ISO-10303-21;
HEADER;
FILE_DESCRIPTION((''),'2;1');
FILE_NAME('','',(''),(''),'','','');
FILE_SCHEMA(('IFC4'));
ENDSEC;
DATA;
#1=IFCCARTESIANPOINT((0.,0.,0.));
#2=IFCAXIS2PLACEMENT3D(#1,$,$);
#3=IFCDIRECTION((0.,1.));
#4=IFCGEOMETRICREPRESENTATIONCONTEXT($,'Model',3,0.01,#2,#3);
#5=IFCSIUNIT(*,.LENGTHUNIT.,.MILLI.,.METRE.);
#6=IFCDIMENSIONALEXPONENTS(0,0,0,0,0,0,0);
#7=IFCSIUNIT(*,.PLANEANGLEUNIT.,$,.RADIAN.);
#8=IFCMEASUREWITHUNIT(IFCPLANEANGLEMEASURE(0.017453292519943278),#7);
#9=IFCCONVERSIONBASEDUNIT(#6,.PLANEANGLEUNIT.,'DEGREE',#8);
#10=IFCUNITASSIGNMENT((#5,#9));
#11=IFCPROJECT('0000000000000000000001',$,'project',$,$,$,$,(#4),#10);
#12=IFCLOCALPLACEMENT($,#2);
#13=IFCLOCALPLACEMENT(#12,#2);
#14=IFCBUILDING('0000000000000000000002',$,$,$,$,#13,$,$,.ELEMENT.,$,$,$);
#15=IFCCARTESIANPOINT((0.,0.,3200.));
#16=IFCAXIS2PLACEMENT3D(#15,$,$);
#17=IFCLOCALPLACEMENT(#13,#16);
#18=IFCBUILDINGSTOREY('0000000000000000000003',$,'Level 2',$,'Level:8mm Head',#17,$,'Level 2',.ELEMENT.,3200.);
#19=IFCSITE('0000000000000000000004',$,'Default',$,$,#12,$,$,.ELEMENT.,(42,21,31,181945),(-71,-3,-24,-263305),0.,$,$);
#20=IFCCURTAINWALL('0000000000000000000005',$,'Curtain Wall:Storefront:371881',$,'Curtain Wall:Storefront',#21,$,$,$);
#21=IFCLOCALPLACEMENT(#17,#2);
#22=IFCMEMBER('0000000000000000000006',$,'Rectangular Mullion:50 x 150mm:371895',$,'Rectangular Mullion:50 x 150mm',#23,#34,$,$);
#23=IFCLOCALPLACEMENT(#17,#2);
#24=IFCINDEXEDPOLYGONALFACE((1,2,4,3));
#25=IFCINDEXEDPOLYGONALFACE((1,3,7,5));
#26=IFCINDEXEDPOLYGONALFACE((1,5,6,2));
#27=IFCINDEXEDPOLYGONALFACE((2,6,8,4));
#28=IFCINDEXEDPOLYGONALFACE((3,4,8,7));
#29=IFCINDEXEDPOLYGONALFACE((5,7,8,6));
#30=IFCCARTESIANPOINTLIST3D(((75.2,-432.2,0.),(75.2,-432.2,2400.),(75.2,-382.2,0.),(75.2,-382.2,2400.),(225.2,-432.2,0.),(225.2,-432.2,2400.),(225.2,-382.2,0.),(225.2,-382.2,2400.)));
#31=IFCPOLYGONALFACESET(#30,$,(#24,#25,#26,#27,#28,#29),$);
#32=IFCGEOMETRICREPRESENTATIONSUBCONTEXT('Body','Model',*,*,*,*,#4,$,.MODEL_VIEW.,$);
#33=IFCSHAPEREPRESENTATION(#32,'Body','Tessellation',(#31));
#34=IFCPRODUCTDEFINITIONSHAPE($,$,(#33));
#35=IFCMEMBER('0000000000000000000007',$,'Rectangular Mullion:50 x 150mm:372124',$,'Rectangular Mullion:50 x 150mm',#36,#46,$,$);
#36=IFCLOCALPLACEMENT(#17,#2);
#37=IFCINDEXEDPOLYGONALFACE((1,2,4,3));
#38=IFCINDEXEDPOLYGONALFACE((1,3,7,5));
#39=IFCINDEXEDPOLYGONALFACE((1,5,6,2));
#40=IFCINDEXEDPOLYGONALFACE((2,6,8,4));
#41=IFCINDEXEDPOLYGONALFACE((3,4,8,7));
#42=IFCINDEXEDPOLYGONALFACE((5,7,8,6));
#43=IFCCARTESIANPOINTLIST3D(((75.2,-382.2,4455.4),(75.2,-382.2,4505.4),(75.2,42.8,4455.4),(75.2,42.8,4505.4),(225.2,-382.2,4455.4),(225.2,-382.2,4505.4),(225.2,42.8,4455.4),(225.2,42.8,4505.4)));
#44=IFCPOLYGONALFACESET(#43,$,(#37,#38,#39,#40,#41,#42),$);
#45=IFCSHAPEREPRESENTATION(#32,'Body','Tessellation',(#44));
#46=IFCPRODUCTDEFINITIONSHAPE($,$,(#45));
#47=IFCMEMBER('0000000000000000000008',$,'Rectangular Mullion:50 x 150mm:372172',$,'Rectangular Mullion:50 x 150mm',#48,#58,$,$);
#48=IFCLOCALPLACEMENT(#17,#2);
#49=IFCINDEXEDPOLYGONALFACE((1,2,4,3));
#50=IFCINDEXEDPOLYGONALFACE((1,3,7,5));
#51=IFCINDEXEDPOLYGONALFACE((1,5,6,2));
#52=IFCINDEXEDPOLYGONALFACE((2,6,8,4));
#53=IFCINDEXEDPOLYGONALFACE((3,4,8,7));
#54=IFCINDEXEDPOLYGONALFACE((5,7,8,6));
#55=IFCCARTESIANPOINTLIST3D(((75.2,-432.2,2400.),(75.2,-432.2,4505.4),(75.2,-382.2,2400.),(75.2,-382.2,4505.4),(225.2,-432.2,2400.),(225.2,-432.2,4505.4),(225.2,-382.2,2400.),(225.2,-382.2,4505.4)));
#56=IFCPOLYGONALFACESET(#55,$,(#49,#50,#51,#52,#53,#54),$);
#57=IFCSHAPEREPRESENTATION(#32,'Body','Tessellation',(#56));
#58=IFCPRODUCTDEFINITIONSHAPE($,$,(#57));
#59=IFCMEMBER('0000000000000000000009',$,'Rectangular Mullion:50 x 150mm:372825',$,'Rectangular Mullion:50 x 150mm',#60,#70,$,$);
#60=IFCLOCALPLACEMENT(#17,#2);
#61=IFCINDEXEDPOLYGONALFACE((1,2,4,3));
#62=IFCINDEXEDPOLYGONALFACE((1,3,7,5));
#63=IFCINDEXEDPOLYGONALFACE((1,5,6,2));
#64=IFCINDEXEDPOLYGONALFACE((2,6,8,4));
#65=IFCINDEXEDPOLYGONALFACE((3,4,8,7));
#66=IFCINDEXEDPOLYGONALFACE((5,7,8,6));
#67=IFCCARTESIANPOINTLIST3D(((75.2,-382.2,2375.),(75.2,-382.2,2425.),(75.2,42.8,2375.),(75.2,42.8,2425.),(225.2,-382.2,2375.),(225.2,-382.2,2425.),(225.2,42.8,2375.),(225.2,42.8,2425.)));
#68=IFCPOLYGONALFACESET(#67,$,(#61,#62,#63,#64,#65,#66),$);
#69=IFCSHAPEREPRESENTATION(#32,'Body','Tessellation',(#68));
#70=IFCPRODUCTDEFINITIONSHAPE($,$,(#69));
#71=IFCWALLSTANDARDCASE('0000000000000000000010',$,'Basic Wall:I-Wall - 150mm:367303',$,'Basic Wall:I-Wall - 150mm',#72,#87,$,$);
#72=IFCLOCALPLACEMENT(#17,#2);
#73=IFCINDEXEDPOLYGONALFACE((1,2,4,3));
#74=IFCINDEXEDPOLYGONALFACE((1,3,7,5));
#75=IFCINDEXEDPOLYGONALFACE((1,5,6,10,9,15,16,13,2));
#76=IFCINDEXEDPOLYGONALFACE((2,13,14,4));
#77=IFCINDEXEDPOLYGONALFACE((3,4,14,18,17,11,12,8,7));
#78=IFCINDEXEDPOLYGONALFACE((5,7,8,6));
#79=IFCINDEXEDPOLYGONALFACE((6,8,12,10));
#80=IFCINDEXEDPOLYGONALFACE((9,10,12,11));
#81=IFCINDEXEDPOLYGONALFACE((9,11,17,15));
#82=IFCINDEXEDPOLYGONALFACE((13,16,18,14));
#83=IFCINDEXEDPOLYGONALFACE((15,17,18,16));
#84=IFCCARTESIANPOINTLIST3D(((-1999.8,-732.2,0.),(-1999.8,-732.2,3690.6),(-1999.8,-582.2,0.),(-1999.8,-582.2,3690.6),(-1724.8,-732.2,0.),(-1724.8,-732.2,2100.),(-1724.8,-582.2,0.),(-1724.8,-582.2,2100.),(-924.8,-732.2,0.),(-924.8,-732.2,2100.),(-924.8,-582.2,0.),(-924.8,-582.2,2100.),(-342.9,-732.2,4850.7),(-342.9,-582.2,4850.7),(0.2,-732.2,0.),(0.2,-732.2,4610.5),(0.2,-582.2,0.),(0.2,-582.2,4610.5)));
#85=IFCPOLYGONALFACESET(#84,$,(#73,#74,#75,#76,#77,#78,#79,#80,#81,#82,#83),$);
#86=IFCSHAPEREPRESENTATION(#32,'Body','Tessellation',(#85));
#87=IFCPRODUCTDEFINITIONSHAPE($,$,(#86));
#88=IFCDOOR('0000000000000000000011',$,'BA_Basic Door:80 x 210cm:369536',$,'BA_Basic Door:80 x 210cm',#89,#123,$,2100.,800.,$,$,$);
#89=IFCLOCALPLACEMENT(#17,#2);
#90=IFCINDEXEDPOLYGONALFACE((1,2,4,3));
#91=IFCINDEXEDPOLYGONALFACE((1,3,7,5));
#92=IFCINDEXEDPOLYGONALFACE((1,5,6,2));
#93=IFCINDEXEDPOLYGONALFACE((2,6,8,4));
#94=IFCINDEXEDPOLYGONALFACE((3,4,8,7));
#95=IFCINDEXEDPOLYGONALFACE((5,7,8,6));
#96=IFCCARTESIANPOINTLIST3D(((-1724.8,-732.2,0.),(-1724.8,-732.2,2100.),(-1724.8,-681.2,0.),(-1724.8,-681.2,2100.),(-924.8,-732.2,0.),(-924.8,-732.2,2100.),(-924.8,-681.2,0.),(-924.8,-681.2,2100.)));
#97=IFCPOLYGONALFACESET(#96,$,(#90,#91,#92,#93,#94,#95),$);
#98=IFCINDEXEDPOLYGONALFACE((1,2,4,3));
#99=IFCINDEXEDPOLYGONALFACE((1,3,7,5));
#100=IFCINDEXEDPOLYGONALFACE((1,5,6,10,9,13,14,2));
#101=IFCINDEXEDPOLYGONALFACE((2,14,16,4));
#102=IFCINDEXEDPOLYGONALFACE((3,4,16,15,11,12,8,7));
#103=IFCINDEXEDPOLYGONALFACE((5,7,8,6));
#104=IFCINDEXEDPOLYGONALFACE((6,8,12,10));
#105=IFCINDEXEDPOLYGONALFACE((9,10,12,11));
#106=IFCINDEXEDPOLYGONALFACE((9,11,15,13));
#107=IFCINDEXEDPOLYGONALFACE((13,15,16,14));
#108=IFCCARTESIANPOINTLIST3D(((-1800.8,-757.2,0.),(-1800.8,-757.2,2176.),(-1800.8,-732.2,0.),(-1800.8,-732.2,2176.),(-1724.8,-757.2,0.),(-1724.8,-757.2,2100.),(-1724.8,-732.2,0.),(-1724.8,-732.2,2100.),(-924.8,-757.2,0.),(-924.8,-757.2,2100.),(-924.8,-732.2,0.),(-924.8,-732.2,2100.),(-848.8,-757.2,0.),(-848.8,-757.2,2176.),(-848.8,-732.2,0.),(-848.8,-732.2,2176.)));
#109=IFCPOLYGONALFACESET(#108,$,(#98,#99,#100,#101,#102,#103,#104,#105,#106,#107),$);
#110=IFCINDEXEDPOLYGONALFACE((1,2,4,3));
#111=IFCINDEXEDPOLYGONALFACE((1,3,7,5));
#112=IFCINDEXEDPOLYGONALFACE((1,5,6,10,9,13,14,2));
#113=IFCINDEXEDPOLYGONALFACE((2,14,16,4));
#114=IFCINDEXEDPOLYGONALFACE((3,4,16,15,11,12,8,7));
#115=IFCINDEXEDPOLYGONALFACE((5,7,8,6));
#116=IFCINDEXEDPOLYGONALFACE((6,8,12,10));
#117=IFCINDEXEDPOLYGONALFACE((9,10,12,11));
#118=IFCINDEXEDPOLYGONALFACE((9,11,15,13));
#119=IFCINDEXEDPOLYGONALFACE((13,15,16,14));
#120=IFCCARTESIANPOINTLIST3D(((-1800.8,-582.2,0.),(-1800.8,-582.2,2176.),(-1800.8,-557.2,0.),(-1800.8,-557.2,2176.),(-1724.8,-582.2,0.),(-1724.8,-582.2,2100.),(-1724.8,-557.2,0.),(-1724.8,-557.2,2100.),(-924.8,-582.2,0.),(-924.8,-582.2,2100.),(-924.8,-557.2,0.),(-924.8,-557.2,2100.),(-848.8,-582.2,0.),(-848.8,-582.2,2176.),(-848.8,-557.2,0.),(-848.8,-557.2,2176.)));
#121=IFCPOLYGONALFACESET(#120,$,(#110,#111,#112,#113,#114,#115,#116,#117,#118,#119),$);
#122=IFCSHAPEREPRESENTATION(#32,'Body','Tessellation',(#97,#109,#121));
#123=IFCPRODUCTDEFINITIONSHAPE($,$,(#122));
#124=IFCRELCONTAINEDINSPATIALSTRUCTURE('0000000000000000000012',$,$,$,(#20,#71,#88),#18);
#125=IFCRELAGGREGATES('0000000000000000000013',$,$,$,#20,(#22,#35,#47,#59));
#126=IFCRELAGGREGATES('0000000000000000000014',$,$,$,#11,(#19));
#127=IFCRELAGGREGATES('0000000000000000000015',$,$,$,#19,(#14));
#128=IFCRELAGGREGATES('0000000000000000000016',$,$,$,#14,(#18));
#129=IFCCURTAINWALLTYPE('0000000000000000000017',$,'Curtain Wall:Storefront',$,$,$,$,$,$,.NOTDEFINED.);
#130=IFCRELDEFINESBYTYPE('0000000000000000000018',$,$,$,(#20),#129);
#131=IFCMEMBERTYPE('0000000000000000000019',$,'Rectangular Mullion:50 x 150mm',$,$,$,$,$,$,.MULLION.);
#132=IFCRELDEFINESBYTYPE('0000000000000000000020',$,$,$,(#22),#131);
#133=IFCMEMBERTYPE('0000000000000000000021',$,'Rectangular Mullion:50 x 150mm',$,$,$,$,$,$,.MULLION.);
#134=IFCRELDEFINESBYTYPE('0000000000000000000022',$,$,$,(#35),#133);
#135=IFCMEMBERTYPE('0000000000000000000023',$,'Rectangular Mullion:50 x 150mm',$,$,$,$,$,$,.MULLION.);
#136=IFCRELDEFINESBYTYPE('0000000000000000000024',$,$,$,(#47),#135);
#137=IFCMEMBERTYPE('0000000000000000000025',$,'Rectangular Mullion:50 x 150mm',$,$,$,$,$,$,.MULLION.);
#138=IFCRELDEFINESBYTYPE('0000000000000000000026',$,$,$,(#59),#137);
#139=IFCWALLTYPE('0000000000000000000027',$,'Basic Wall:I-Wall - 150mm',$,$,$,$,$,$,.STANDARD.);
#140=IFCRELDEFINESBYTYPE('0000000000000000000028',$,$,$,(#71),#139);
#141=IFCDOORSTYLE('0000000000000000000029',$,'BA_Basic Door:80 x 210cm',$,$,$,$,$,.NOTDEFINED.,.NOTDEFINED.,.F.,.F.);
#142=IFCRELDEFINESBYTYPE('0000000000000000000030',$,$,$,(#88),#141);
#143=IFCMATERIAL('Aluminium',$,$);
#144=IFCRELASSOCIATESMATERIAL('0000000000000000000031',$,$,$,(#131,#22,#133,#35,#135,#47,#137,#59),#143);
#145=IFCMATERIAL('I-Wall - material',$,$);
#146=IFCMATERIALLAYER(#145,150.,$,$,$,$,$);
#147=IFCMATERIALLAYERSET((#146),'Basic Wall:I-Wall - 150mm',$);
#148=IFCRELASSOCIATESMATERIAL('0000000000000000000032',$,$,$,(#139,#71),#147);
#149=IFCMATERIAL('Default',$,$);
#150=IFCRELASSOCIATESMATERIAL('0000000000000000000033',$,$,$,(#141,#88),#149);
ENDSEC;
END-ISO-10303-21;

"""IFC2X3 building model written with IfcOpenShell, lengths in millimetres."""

from ifc_helpers import new_model, entity, si_unit, converted_unit, direction, frame, frame_2d, origin, origin_2d_with_axis, place, context, subcontext, project, spatial, polyline, rectangle, outline, extrude, clip, bounded_halfspace, source, transform, mapped, material, layer, layer_set, layer_usage, type_object, type_shapes, element, fill, aggregate, save


model = new_model("IFC2X3")

# Units and contexts
model_context = context("Model", 3, precision=0.01, world=origin(), true_north=direction((0.0, 1.0)))
body_context = subcontext(model_context, "Body", "Model", "MODEL_VIEW")
ifc_project = project(units=[si_unit("LENGTHUNIT", "METRE", prefix="MILLI"), converted_unit("PLANEANGLEUNIT", "DEGREE", entity("IfcPlaneAngleMeasure", 0.017453292519943278), si_unit("PLANEANGLEUNIT", "RADIAN"), dimensions=[0, 0, 0, 0, 0, 0, 0])], contexts=[model_context])

# Site, building, storey
site_placement = place(None, origin())
site = spatial("IfcSite", under=ifc_project, at=site_placement, Name="Default", CompositionType="ELEMENT", RefLatitude=(42, 21, 31, 181945), RefLongitude=(-71, -3, -24, -263305), RefElevation=0.0)
building_placement = place(site_placement, origin())
building = spatial("IfcBuilding", under=site, at=building_placement, CompositionType="ELEMENT")
storey_placement = place(building_placement, frame((0.0, 0.0, 3200.0)))
storey = spatial("IfcBuildingStorey", under=building, at=storey_placement, Name="Level 2", ObjectType="Level:8mm Head", LongName="Level 2", CompositionType="ELEMENT", Elevation=3200.0)

# Curtain wall, member
curtain_wall_type = type_object("IfcCurtainWallType", Name="Curtain Wall:Storefront", PredefinedType="NOTDEFINED")
curtain_wall_1_placement = place(storey_placement, frame((0.0, 0.0, -3200.0)))
curtain_wall_1 = element("IfcCurtainWall", 1, at=curtain_wall_1_placement, inside=storey, type_object=curtain_wall_type, Name="Curtain Wall:Storefront:371881", ObjectType="Curtain Wall:Storefront")
ifc_material_1 = material(Name="Aluminium")
member_type_1 = type_object("IfcMemberType", Name="Rectangular Mullion:50 x 150mm", PredefinedType="MULLION", material=ifc_material_1)
shared_shape_1 = source(origin(), body_context, "Body", "SweptSolid", [
    extrude(rectangle(XDim=50.0, YDim=150.0, at=origin_2d_with_axis()), frame((-25.0, 0.0, -2400.0), z_axis=(0.0, 0.0, 1.0), x_axis=(-1.0, 0.0, 0.0)), (0.0, 0.0, 1.0), 2400.0),
])
type_shapes(member_type_1, [shared_shape_1])
member_1_placement = place(curtain_wall_1_placement, frame((150.2, -432.2, 3200.0), z_axis=(0.0, 0.0, -1.0), x_axis=(0.0, -1.0, 0.0)))
member_1 = element("IfcMember", 2, at=member_1_placement, type_object=member_type_1, material=ifc_material_1, Name="Rectangular Mullion:50 x 150mm:371895", ObjectType="Rectangular Mullion:50 x 150mm", context=body_context, shape_type="MappedRepresentation", body=[
    mapped(shared_shape_1, transform((0.0, 0.0, 0.0), scale=1.0)),
])

# Members
member_type_2 = type_object("IfcMemberType", Name="Rectangular Mullion:50 x 150mm", PredefinedType="MULLION", material=ifc_material_1)
shared_shape_2 = source(origin(), body_context, "Body", "SweptSolid", [
    extrude(rectangle(XDim=50.0, YDim=150.0, at=origin_2d_with_axis()), frame((-25.0, 0.0, -425.0), z_axis=(0.0, 0.0, 1.0), x_axis=(-1.0, 0.0, 0.0)), (0.0, 0.0, 1.0), 425.0),
])
type_shapes(member_type_2, [shared_shape_2])
member_2_placement = place(curtain_wall_1_placement, frame((150.2, -382.2, 7705.4), z_axis=(0.0, -1.0, 0.0), x_axis=(0.0, 0.0, 1.0)))
member_2 = element("IfcMember", 3, at=member_2_placement, type_object=member_type_2, material=ifc_material_1, Name="Rectangular Mullion:50 x 150mm:372124", ObjectType="Rectangular Mullion:50 x 150mm", context=body_context, shape_type="MappedRepresentation", body=[
    mapped(shared_shape_2, transform((0.0, 0.0, 0.0), scale=1.0)),
])
member_type_3 = type_object("IfcMemberType", Name="Rectangular Mullion:50 x 150mm", PredefinedType="MULLION", material=ifc_material_1)
shared_shape_3 = source(origin(), body_context, "Body", "SweptSolid", [
    extrude(rectangle(XDim=50.0, YDim=150.0, at=origin_2d_with_axis()), frame((-25.0, 0.0, -2105.4), z_axis=(0.0, 0.0, 1.0), x_axis=(-1.0, 0.0, 0.0)), (0.0, 0.0, 1.0), 2105.4),
])
type_shapes(member_type_3, [shared_shape_3])
member_3_placement = place(curtain_wall_1_placement, frame((150.2, -432.2, 5600.0), z_axis=(0.0, 0.0, -1.0), x_axis=(0.0, -1.0, 0.0)))
member_3 = element("IfcMember", 4, at=member_3_placement, type_object=member_type_3, material=ifc_material_1, Name="Rectangular Mullion:50 x 150mm:372172", ObjectType="Rectangular Mullion:50 x 150mm", context=body_context, shape_type="MappedRepresentation", body=[
    mapped(shared_shape_3, transform((0.0, 0.0, 0.0), scale=1.0)),
])
member_type_4 = type_object("IfcMemberType", Name="Rectangular Mullion:50 x 150mm", PredefinedType="MULLION", material=ifc_material_1)
shared_shape_4 = source(origin(), body_context, "Body", "SweptSolid", [
    extrude(rectangle(XDim=50.0, YDim=150.0, at=origin_2d_with_axis()), frame((0.0, 0.0, -425.0), z_axis=(0.0, 0.0, 1.0), x_axis=(-1.0, 0.0, 0.0)), (0.0, 0.0, 1.0), 425.0),
])
type_shapes(member_type_4, [shared_shape_4])
member_4_placement = place(curtain_wall_1_placement, frame((150.2, -382.2, 5600.0), z_axis=(0.0, -1.0, 0.0), x_axis=(0.0, 0.0, 1.0)))
member_4 = element("IfcMember", 5, at=member_4_placement, type_object=member_type_4, material=ifc_material_1, Name="Rectangular Mullion:50 x 150mm:372825", ObjectType="Rectangular Mullion:50 x 150mm", context=body_context, shape_type="MappedRepresentation", body=[
    mapped(shared_shape_4, transform((0.0, 0.0, 0.0), scale=1.0)),
])

# Shared definitions
ifc_material_2 = material(Name="Default")

aggregate(curtain_wall_1, [member_1, member_2, member_3, member_4])

# Wall, opening, door
ifc_material_3 = material(Name="I-Wall - material")
ifc_layer_1 = layer(ifc_material_3, 150.0)
ifc_layer_set_1 = layer_set([ifc_layer_1], Name="Basic Wall:I-Wall - 150mm")
ifc_layer_usage_1 = layer_usage(ifc_layer_set_1, "AXIS2", "NEGATIVE", 75.0)
wall_type_1 = type_object("IfcWallType", Name="Basic Wall:I-Wall - 150mm", PredefinedType="STANDARD", material=ifc_layer_set_1)
wall_1_placement = place(storey_placement, frame((0.2, -657.2, 0.0), z_axis=(0.0, 0.0, 1.0), x_axis=(-1.0, 0.0, 0.0)))
wall_1 = element("IfcWallStandardCase", 6, at=wall_1_placement, inside=storey, type_object=wall_type_1, material=ifc_layer_usage_1, Name="Basic Wall:I-Wall - 150mm:367303", ObjectType="Basic Wall:I-Wall - 150mm", context=body_context, shape_type="Clipping", body=[
    clip(clip(extrude(rectangle(XDim=2000.0, YDim=150.0, at=frame_2d((1000.0, 0.0), x_axis=(-1.0, 0.0))), origin(), (0.0, 0.0, 1.0), 4850.7), bounded_halfspace(frame((2000.0, -75.0, 3690.6), z_axis=(0.573576, 0.0, 0.819152), x_axis=(0.0, 1.0, 0.0)), False, frame((2000.0, -75.0, 3690.6)), polyline([(0.0, 0.0), (0.0, 150.0), (-150.0, 150.0), (-1200.0, 150.0), (-1350.0, 150.0), (-1656.9, 150.0), (-1656.9, 0.0), (0.0, 0.0)]))), bounded_halfspace(frame((0.0, -75.0, 4610.5), z_axis=(-0.573576, 0.0, 0.819152), x_axis=(0.0, -1.0, 0.0)), False, frame((0.0, -75.0, 4610.5)), polyline([(0.0, 0.0), (343.1, 0.0), (343.1, 150.0), (0.0, 150.0), (0.0, 0.0)]))),
])
opening_1_placement = place(wall_1_placement, frame((925.0, -75.0, 0.0)))
opening_1 = element("IfcOpeningElement", 7, at=opening_1_placement, cuts=wall_1, ObjectType="Opening", context=body_context, shape_type="SweptSolid", body=[
    extrude(rectangle(XDim=800.0, YDim=2100.0, at=frame_2d((1050.0, 400.0), x_axis=(0.0, 1.0))), frame((0.0, 0.0, 0.0), z_axis=(0.0, 1.0, 0.0), x_axis=(0.0, 0.0, 1.0)), (0.0, 0.0, 1.0), 150.0),
])
door_style_1 = type_object("IfcDoorStyle", Name="BA_Basic Door:80 x 210cm", ConstructionType="NOTDEFINED", OperationType="NOTDEFINED", ParameterTakesPrecedence=False, Sizeable=False, material=ifc_material_2)
shared_shape_5 = source(origin(), body_context, "Body", "SweptSolid", [
    extrude(rectangle(XDim=51.0, YDim=800.0, at=frame_2d((0.0, 0.0), x_axis=(1.0, 0.0))), frame((400.0, 124.5, 0.0), z_axis=(0.0, 0.0, 1.0), x_axis=(0.0, 1.0, 0.0)), (0.0, 0.0, 1.0), 2100.0),
    extrude(outline(polyline([(-476.0, -1107.0), (476.0, -1107.0), (476.0, 1069.0), (400.0, 1069.0), (400.0, -1031.0), (-400.0, -1031.0), (-400.0, 1069.0), (-476.0, 1069.0), (-476.0, -1107.0)])), frame((400.0, 150.0, 1069.0), z_axis=(0.0, 1.0, 0.0), x_axis=(1.0, 0.0, 0.0)), (0.0, 0.0, 1.0), 25.0),
    extrude(outline(polyline([(-1107.0, -476.0), (1069.0, -476.0), (1069.0, -400.0), (-1031.0, -400.0), (-1031.0, 400.0), (1069.0, 400.0), (1069.0, 476.0), (-1107.0, 476.0), (-1107.0, -476.0)])), frame((400.0, -25.0, 1069.0), z_axis=(0.0, 1.0, 0.0), x_axis=(0.0, 0.0, -1.0)), (0.0, 0.0, 1.0), 25.0),
])
type_shapes(door_style_1, [shared_shape_5])
door_1_placement = place(opening_1_placement, origin())
door_1 = element("IfcDoor", 8, at=door_1_placement, inside=storey, type_object=door_style_1, material=ifc_material_2, Name="BA_Basic Door:80 x 210cm:369536", ObjectType="BA_Basic Door:80 x 210cm", OverallHeight=2100.0, OverallWidth=800.0, context=body_context, shape_type="MappedRepresentation", body=[
    mapped(shared_shape_5, transform((0.0, 0.0, 0.0), scale=1.0)),
])
fill(opening_1, door_1)

save(model, "model.ifc")
